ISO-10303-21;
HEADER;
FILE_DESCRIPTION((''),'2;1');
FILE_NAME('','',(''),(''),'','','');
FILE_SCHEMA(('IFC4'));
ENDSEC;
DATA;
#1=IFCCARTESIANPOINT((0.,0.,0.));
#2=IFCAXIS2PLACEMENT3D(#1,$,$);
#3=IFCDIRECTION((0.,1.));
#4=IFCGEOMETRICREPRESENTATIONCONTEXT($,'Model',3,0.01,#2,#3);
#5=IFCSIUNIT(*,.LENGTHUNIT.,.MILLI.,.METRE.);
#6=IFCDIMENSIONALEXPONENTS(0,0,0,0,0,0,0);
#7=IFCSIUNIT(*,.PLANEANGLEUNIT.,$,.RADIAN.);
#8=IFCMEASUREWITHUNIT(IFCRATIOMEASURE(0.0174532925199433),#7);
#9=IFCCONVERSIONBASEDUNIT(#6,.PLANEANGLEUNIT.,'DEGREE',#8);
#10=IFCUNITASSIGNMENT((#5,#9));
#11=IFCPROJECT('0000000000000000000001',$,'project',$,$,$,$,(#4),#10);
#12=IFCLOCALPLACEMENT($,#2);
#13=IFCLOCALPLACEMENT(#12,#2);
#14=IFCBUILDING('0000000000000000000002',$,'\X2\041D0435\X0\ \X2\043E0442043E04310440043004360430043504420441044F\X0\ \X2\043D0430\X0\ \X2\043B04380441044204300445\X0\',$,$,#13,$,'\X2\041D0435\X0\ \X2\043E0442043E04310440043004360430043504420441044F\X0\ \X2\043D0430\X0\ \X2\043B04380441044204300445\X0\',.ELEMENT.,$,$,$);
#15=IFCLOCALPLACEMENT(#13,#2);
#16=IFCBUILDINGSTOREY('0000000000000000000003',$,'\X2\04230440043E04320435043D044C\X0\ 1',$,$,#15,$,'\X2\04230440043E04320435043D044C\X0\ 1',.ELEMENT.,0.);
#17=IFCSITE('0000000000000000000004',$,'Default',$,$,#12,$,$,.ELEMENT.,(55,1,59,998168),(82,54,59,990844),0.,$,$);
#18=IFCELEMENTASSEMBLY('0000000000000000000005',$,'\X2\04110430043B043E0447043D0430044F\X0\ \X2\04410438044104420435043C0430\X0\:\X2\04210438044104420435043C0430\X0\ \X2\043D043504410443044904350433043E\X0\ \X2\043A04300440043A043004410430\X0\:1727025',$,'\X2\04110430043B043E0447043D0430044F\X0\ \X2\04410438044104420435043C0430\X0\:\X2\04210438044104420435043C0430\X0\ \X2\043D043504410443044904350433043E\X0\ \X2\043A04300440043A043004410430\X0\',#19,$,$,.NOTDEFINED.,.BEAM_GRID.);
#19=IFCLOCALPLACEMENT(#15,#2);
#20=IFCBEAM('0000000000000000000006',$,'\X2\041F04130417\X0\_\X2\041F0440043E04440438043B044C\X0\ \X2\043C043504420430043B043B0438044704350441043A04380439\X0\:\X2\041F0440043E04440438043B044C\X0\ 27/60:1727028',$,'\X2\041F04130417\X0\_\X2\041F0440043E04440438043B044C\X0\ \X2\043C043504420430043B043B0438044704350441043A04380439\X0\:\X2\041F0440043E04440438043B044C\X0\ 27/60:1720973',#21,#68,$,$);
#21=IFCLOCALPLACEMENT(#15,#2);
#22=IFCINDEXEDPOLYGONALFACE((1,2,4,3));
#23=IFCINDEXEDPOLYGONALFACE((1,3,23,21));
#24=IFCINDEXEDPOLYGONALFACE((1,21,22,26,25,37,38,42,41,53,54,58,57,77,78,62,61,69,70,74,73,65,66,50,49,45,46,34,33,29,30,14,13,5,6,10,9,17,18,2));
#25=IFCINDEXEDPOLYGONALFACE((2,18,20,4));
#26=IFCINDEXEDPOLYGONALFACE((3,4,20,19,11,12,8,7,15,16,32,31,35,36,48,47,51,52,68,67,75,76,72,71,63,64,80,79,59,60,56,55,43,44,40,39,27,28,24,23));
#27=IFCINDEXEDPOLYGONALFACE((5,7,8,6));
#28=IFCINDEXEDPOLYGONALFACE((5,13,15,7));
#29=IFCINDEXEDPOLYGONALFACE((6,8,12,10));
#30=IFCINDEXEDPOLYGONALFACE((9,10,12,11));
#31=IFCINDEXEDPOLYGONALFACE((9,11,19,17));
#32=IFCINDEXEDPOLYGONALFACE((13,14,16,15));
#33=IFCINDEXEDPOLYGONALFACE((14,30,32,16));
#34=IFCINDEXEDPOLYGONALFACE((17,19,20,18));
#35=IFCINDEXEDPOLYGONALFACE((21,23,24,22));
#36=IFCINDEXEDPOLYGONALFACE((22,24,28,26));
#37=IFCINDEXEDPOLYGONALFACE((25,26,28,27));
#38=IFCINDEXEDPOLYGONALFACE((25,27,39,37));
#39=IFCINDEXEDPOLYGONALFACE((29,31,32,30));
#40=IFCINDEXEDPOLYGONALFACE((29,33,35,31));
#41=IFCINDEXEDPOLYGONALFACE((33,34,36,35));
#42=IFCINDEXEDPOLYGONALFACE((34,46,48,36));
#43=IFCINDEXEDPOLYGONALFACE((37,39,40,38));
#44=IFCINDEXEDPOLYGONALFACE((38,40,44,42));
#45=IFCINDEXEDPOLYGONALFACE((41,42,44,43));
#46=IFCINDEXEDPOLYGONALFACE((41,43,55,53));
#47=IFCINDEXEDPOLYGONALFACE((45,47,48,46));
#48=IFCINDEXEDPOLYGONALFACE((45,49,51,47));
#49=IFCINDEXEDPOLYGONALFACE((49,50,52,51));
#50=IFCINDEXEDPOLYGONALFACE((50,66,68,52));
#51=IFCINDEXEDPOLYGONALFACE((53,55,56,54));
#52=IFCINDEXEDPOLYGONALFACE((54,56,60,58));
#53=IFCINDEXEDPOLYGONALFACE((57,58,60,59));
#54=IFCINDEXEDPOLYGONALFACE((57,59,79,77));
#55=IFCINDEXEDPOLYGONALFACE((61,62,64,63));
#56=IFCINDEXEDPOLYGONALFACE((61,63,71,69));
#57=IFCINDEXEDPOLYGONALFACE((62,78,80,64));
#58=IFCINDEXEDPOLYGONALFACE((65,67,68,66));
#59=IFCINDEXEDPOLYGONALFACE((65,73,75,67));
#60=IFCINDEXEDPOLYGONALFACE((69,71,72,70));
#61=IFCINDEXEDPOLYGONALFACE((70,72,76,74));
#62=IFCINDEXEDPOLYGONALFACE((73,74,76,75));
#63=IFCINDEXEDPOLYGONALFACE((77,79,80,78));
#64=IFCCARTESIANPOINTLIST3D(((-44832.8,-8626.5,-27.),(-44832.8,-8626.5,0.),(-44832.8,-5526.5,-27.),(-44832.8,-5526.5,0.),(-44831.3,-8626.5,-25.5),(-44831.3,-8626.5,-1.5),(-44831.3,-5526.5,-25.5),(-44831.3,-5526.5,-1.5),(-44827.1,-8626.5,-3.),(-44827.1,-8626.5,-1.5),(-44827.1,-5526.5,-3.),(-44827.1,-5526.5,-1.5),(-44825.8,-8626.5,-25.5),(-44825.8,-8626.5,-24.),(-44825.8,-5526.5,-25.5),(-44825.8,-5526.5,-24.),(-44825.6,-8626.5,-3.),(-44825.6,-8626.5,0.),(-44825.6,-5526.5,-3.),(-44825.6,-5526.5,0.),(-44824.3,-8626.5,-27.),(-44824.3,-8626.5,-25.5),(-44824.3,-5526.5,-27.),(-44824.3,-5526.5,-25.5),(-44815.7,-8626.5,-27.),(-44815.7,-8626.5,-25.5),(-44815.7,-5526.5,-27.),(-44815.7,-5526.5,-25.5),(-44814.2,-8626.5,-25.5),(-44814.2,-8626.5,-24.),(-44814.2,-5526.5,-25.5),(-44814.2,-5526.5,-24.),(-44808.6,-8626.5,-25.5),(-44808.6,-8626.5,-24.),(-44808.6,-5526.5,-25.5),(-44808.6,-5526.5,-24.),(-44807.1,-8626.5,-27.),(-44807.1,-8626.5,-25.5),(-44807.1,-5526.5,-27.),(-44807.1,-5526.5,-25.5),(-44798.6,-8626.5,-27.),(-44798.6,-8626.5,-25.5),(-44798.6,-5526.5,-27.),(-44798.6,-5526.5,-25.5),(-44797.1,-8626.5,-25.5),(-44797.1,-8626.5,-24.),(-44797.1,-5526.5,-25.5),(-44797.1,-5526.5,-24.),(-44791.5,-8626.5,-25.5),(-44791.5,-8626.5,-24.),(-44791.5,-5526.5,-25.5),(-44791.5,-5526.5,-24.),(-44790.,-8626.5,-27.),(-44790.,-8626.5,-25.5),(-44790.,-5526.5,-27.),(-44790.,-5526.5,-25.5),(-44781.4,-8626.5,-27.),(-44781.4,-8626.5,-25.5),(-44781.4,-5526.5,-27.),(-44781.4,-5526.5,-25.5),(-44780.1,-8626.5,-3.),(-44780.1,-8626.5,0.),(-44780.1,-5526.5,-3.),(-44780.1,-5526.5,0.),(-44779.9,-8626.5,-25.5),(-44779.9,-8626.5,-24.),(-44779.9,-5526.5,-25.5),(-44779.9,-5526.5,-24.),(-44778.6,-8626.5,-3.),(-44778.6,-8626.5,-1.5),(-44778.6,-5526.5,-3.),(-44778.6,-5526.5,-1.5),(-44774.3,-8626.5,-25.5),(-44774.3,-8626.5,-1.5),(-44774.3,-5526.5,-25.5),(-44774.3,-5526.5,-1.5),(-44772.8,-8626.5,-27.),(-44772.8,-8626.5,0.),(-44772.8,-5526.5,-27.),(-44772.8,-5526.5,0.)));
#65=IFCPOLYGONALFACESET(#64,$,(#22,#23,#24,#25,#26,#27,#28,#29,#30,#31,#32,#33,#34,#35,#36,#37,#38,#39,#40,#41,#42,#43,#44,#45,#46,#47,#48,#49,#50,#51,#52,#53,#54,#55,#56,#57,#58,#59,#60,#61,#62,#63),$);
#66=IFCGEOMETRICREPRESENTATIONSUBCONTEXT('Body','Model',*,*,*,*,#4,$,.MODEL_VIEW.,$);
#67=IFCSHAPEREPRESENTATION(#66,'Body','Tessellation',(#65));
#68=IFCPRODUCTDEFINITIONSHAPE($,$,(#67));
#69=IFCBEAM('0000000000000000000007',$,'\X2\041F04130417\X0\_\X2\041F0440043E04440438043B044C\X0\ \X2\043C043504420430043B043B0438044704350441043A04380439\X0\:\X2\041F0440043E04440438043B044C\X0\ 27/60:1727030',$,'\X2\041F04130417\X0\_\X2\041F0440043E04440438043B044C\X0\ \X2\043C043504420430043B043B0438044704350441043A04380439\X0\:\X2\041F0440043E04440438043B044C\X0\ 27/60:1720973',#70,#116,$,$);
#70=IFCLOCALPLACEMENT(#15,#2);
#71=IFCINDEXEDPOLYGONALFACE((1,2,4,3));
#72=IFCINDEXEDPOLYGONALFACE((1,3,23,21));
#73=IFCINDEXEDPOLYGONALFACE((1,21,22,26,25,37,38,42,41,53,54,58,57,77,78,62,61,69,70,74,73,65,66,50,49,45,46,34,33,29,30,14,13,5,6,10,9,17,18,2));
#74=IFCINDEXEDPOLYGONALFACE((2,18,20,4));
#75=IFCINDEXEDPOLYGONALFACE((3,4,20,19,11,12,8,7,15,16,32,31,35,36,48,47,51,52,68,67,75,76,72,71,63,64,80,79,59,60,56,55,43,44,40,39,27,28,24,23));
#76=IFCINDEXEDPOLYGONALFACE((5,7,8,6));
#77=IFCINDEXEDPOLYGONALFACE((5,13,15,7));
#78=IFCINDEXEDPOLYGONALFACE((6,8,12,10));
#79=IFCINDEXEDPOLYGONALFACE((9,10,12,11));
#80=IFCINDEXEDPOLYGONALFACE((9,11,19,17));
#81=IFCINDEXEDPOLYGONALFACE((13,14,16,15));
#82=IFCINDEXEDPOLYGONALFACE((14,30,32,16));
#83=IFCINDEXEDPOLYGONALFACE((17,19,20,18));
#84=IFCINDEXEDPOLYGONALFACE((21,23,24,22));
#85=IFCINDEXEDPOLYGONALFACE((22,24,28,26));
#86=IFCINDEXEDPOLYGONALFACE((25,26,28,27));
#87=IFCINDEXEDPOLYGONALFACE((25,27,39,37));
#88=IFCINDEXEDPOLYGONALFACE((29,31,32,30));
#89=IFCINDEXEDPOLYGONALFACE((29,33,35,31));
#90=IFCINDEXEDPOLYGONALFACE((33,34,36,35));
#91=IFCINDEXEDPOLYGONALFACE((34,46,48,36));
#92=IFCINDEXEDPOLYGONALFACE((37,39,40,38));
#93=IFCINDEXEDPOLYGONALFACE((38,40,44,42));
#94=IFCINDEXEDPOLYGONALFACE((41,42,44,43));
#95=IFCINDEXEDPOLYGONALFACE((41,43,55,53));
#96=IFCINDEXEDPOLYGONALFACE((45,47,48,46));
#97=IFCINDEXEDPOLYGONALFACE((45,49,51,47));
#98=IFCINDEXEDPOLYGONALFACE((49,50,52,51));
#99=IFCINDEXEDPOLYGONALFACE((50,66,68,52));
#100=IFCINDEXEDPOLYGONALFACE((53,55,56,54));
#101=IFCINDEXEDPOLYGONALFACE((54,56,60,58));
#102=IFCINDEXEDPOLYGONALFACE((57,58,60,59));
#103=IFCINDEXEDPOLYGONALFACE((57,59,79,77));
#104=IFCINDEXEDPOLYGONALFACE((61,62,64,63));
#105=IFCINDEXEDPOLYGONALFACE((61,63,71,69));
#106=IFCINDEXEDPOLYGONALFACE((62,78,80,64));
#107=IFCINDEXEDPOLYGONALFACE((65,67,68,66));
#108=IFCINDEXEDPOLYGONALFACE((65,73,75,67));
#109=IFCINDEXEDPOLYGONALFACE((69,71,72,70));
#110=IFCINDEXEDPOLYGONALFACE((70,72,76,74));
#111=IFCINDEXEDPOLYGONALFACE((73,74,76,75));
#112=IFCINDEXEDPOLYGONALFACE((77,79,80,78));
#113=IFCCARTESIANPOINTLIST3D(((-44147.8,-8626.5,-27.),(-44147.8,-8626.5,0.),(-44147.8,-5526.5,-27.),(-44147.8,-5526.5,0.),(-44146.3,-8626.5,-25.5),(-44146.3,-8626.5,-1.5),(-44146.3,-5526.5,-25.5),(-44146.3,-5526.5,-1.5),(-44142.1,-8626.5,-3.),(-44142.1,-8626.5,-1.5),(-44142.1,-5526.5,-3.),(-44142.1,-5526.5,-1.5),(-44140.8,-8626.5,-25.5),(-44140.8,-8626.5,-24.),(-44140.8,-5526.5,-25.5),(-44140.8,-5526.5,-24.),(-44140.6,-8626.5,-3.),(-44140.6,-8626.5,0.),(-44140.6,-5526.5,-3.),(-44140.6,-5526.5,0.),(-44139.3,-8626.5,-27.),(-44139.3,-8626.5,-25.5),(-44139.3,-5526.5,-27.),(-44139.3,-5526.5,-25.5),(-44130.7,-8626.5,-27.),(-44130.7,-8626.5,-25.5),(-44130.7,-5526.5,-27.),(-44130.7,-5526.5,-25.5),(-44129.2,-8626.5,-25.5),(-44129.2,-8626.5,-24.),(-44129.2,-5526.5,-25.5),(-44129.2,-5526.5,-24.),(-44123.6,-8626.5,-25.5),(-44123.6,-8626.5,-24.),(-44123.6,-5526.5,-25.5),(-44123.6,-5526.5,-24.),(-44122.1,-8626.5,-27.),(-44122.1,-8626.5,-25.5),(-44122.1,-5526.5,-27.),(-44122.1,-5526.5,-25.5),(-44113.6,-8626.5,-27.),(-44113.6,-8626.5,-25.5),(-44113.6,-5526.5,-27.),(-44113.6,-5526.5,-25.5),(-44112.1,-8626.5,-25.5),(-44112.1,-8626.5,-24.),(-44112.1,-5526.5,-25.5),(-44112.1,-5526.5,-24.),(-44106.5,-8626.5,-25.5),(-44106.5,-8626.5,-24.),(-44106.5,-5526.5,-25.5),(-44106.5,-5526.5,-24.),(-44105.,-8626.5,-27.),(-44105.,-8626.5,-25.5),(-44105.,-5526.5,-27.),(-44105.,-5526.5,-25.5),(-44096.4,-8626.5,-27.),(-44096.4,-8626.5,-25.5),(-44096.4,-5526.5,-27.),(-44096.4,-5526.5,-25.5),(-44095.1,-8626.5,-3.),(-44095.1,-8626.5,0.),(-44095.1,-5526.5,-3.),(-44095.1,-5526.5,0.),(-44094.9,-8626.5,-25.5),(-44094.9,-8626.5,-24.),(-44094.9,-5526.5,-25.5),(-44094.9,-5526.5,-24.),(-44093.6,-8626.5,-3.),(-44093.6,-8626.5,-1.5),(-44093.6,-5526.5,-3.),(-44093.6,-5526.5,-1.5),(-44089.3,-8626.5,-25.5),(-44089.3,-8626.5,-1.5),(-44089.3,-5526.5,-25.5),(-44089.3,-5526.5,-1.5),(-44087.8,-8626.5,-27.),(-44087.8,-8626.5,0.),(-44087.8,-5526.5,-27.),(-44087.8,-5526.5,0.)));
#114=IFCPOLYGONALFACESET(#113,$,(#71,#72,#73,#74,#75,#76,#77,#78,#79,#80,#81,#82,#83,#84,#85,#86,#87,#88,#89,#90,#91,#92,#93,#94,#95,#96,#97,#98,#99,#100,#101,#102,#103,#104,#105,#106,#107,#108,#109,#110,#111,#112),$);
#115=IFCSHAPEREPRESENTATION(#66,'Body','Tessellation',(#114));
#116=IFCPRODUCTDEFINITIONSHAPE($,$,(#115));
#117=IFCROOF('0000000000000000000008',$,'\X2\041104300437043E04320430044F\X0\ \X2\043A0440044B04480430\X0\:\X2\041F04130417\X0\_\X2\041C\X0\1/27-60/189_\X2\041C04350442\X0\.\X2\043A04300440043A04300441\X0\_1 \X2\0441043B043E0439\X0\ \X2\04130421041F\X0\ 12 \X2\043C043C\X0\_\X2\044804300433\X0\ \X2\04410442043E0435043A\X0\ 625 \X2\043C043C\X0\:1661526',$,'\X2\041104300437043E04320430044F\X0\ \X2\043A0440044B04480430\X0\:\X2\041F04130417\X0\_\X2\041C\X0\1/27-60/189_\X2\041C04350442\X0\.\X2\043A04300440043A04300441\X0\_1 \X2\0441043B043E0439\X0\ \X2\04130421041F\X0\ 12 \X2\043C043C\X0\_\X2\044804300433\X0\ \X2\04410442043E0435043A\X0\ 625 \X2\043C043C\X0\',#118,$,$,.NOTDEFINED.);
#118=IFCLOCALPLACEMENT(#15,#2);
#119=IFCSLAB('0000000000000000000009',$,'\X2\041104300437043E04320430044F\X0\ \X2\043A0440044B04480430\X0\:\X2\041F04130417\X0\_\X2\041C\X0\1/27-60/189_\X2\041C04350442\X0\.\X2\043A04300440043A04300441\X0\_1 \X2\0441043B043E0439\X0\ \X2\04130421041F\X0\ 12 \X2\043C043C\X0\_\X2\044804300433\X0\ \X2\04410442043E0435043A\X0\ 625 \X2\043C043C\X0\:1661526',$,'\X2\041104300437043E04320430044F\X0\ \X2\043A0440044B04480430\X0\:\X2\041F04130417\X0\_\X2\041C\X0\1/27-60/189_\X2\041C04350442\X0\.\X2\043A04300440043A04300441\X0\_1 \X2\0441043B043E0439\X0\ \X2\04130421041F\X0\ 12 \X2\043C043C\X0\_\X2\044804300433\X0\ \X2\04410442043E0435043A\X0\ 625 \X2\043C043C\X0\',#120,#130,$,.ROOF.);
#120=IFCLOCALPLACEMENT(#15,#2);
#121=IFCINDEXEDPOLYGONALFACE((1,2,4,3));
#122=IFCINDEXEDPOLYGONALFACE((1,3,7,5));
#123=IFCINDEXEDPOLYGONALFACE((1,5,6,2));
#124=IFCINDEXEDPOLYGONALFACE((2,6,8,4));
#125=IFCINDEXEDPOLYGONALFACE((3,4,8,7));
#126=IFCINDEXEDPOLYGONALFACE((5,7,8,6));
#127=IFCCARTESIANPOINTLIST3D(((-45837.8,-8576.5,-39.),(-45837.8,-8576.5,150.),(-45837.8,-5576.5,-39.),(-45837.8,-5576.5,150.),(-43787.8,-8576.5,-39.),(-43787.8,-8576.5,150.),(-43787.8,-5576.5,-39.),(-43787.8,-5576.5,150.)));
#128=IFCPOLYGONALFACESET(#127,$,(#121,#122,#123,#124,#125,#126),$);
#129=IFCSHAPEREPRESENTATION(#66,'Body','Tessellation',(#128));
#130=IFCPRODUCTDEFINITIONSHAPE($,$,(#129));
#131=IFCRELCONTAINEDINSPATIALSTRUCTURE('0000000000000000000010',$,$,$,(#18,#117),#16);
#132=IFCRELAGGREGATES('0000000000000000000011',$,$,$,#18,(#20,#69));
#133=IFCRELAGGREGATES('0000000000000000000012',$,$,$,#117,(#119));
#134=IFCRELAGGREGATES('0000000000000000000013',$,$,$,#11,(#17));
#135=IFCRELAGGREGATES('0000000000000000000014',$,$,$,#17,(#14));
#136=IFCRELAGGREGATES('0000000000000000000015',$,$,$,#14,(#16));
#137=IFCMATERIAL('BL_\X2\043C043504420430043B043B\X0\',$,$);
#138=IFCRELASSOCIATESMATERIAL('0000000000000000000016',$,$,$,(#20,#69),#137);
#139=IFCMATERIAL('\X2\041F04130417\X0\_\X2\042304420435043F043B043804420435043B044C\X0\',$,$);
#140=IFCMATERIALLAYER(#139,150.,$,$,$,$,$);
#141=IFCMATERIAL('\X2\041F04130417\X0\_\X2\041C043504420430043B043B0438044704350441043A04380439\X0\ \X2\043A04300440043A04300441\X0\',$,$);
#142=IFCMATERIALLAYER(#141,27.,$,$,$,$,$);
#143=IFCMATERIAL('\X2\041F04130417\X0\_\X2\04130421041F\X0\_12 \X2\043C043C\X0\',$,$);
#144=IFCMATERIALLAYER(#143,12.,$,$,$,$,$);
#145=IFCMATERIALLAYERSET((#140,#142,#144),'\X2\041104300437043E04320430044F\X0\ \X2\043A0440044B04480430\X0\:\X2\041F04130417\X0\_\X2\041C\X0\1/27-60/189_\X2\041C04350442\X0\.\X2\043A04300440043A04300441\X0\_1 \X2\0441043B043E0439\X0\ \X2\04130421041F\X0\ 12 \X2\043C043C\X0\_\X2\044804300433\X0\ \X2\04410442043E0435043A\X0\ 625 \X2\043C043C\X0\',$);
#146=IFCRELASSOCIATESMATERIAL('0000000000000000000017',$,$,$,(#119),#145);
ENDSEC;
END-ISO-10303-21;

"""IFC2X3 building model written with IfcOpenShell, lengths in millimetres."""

from ifc_helpers import new_model, entity, si_unit, converted_unit, direction, frame, frame_2d, origin, place, context, subcontext, project, spatial, polyline, rectangle, outline, extrude, material, layer, layer_set, element, aggregate, save


model = new_model("IFC2X3")

# Units and contexts
model_context = context("Model", 3, precision=0.01, world=origin(), true_north=direction((0.0, 1.0)))
body_context = subcontext(model_context, "Body", "Model", "MODEL_VIEW")
ifc_project = project(units=[si_unit("LENGTHUNIT", "METRE", prefix="MILLI"), converted_unit("PLANEANGLEUNIT", "DEGREE", entity("IfcRatioMeasure", 0.0174532925199433), si_unit("PLANEANGLEUNIT", "RADIAN"), dimensions=[0, 0, 0, 0, 0, 0, 0])], contexts=[model_context])

# Site, building, storey
site_placement = place(None, origin())
site = spatial("IfcSite", under=ifc_project, at=site_placement, Name="Default", CompositionType="ELEMENT", RefLatitude=(55, 1, 59, 998168), RefLongitude=(82, 54, 59, 990844), RefElevation=0.0)
building_placement = place(site_placement, origin())
building = spatial("IfcBuilding", under=site, at=building_placement, Name="Не отображается на листах", LongName="Не отображается на листах", CompositionType="ELEMENT")
storey_placement = place(building_placement, frame((0.0, 0.0, 0.0)))
storey = spatial("IfcBuildingStorey", under=building, at=storey_placement, Name="Уровень 1", LongName="Уровень 1", CompositionType="ELEMENT", Elevation=0.0)

# Element assembly, beams
ifc_material_1 = material(Name="BL_металл")
assembly_1_placement = place(storey_placement, origin())
assembly_1 = element("IfcElementAssembly", 1, at=assembly_1_placement, inside=storey, Name="Балочная система:Система несущего каркаса:1727025", ObjectType="Балочная система:Система несущего каркаса", AssemblyPlace="NOTDEFINED", PredefinedType="BEAM_GRID")
beam_1_placement = place(assembly_1_placement, frame((-44802.8, -8626.5, 0.0), z_axis=(0.0, 0.0, 1.0), x_axis=(0.0, 1.0, 0.0)))
beam_1 = element("IfcBeam", 2, at=beam_1_placement, material=ifc_material_1, Name="ПГЗ_Профиль металлический:Профиль 27/60:1727028", ObjectType="ПГЗ_Профиль металлический:Профиль 27/60:1720973", context=body_context, shape_type="SweptSolid", body=[
    extrude(outline(polyline([(-18.4, -30.0), (8.6, -30.0), (8.6, -21.4), (7.1, -21.4), (7.1, -12.9), (8.6, -12.9), (8.6, -4.3), (7.1, -4.3), (7.1, 4.3), (8.6, 4.3), (8.6, 12.9), (7.1, 12.9), (7.1, 21.4), (8.6, 21.4), (8.6, 30.0), (-18.4, 30.0), (-18.4, 22.7), (-15.4, 22.7), (-15.4, 24.2), (-16.9, 24.2), (-16.9, 28.5), (7.1, 28.5), (7.1, 22.9), (5.6, 22.9), (5.6, 11.4), (7.1, 11.4), (7.1, 5.8), (5.6, 5.8), (5.6, -5.8), (7.1, -5.8), (7.1, -11.4), (5.6, -11.4), (5.6, -22.9), (7.1, -22.9), (7.1, -28.5), (-16.9, -28.5), (-16.9, -24.2), (-15.4, -24.2), (-15.4, -22.7), (-18.4, -22.7), (-18.4, -30.0)])), frame((0.0, 0.0, -18.4), z_axis=(1.0, 0.0, 0.0), x_axis=(0.0, 0.0, -1.0)), (0.0, 0.0, 1.0), 3100.0),
])
beam_2_placement = place(assembly_1_placement, frame((-44117.8, -8626.5, 0.0), z_axis=(0.0, 0.0, 1.0), x_axis=(0.0, 1.0, 0.0)))
beam_2 = element("IfcBeam", 3, at=beam_2_placement, material=ifc_material_1, Name="ПГЗ_Профиль металлический:Профиль 27/60:1727030", ObjectType="ПГЗ_Профиль металлический:Профиль 27/60:1720973", context=body_context, shape_type="SweptSolid", body=[
    extrude(outline(polyline([(-18.4, -30.0), (8.6, -30.0), (8.6, -21.4), (7.1, -21.4), (7.1, -12.9), (8.6, -12.9), (8.6, -4.3), (7.1, -4.3), (7.1, 4.3), (8.6, 4.3), (8.6, 12.9), (7.1, 12.9), (7.1, 21.4), (8.6, 21.4), (8.6, 30.0), (-18.4, 30.0), (-18.4, 22.7), (-15.4, 22.7), (-15.4, 24.2), (-16.9, 24.2), (-16.9, 28.5), (7.1, 28.5), (7.1, 22.9), (5.6, 22.9), (5.6, 11.4), (7.1, 11.4), (7.1, 5.8), (5.6, 5.8), (5.6, -5.8), (7.1, -5.8), (7.1, -11.4), (5.6, -11.4), (5.6, -22.9), (7.1, -22.9), (7.1, -28.5), (-16.9, -28.5), (-16.9, -24.2), (-15.4, -24.2), (-15.4, -22.7), (-18.4, -22.7), (-18.4, -30.0)])), frame((0.0, 0.0, -18.4), z_axis=(1.0, 0.0, 0.0), x_axis=(0.0, 0.0, -1.0)), (0.0, 0.0, 1.0), 3100.0),
])
aggregate(assembly_1, [beam_1, beam_2])

# Roof, slab
roof_placement = place(storey_placement, frame((-45837.8, -8576.5, -39.0)))
roof = element("IfcRoof", 4, at=roof_placement, inside=storey, Name="Базовая крыша:ПГЗ_М1/27-60/189_Мет.каркас_1 слой ГСП 12 мм_шаг стоек 625 мм:1661526", ObjectType="Базовая крыша:ПГЗ_М1/27-60/189_Мет.каркас_1 слой ГСП 12 мм_шаг стоек 625 мм", ShapeType="NOTDEFINED")
ifc_material_2 = material(Name="ПГЗ_Утеплитель")
ifc_layer_1 = layer(ifc_material_2, 150.0)
ifc_material_3 = material(Name="ПГЗ_Металлический каркас")
ifc_layer_2 = layer(ifc_material_3, 27.0)
ifc_material_4 = material(Name="ПГЗ_ГСП_12 мм")
ifc_layer_3 = layer(ifc_material_4, 12.0)
ifc_layer_set = layer_set([ifc_layer_1, ifc_layer_2, ifc_layer_3], Name="Базовая крыша:ПГЗ_М1/27-60/189_Мет.каркас_1 слой ГСП 12 мм_шаг стоек 625 мм")
slab_placement = place(roof_placement, origin())
slab = element("IfcSlab", 5, at=slab_placement, material=ifc_layer_set, Name="Базовая крыша:ПГЗ_М1/27-60/189_Мет.каркас_1 слой ГСП 12 мм_шаг стоек 625 мм:1661526", ObjectType="Базовая крыша:ПГЗ_М1/27-60/189_Мет.каркас_1 слой ГСП 12 мм_шаг стоек 625 мм", PredefinedType="ROOF", context=body_context, shape_type="SweptSolid", body=[
    extrude(rectangle(XDim=2050.0, YDim=3000.0, at=frame_2d((0.0, 0.0), x_axis=(1.0, 0.0))), frame((1025.0, 1500.0, 0.0)), (0.0, 0.0, 1.0), 189.0),
])
aggregate(roof, [slab])

save(model, "model.ifc")
